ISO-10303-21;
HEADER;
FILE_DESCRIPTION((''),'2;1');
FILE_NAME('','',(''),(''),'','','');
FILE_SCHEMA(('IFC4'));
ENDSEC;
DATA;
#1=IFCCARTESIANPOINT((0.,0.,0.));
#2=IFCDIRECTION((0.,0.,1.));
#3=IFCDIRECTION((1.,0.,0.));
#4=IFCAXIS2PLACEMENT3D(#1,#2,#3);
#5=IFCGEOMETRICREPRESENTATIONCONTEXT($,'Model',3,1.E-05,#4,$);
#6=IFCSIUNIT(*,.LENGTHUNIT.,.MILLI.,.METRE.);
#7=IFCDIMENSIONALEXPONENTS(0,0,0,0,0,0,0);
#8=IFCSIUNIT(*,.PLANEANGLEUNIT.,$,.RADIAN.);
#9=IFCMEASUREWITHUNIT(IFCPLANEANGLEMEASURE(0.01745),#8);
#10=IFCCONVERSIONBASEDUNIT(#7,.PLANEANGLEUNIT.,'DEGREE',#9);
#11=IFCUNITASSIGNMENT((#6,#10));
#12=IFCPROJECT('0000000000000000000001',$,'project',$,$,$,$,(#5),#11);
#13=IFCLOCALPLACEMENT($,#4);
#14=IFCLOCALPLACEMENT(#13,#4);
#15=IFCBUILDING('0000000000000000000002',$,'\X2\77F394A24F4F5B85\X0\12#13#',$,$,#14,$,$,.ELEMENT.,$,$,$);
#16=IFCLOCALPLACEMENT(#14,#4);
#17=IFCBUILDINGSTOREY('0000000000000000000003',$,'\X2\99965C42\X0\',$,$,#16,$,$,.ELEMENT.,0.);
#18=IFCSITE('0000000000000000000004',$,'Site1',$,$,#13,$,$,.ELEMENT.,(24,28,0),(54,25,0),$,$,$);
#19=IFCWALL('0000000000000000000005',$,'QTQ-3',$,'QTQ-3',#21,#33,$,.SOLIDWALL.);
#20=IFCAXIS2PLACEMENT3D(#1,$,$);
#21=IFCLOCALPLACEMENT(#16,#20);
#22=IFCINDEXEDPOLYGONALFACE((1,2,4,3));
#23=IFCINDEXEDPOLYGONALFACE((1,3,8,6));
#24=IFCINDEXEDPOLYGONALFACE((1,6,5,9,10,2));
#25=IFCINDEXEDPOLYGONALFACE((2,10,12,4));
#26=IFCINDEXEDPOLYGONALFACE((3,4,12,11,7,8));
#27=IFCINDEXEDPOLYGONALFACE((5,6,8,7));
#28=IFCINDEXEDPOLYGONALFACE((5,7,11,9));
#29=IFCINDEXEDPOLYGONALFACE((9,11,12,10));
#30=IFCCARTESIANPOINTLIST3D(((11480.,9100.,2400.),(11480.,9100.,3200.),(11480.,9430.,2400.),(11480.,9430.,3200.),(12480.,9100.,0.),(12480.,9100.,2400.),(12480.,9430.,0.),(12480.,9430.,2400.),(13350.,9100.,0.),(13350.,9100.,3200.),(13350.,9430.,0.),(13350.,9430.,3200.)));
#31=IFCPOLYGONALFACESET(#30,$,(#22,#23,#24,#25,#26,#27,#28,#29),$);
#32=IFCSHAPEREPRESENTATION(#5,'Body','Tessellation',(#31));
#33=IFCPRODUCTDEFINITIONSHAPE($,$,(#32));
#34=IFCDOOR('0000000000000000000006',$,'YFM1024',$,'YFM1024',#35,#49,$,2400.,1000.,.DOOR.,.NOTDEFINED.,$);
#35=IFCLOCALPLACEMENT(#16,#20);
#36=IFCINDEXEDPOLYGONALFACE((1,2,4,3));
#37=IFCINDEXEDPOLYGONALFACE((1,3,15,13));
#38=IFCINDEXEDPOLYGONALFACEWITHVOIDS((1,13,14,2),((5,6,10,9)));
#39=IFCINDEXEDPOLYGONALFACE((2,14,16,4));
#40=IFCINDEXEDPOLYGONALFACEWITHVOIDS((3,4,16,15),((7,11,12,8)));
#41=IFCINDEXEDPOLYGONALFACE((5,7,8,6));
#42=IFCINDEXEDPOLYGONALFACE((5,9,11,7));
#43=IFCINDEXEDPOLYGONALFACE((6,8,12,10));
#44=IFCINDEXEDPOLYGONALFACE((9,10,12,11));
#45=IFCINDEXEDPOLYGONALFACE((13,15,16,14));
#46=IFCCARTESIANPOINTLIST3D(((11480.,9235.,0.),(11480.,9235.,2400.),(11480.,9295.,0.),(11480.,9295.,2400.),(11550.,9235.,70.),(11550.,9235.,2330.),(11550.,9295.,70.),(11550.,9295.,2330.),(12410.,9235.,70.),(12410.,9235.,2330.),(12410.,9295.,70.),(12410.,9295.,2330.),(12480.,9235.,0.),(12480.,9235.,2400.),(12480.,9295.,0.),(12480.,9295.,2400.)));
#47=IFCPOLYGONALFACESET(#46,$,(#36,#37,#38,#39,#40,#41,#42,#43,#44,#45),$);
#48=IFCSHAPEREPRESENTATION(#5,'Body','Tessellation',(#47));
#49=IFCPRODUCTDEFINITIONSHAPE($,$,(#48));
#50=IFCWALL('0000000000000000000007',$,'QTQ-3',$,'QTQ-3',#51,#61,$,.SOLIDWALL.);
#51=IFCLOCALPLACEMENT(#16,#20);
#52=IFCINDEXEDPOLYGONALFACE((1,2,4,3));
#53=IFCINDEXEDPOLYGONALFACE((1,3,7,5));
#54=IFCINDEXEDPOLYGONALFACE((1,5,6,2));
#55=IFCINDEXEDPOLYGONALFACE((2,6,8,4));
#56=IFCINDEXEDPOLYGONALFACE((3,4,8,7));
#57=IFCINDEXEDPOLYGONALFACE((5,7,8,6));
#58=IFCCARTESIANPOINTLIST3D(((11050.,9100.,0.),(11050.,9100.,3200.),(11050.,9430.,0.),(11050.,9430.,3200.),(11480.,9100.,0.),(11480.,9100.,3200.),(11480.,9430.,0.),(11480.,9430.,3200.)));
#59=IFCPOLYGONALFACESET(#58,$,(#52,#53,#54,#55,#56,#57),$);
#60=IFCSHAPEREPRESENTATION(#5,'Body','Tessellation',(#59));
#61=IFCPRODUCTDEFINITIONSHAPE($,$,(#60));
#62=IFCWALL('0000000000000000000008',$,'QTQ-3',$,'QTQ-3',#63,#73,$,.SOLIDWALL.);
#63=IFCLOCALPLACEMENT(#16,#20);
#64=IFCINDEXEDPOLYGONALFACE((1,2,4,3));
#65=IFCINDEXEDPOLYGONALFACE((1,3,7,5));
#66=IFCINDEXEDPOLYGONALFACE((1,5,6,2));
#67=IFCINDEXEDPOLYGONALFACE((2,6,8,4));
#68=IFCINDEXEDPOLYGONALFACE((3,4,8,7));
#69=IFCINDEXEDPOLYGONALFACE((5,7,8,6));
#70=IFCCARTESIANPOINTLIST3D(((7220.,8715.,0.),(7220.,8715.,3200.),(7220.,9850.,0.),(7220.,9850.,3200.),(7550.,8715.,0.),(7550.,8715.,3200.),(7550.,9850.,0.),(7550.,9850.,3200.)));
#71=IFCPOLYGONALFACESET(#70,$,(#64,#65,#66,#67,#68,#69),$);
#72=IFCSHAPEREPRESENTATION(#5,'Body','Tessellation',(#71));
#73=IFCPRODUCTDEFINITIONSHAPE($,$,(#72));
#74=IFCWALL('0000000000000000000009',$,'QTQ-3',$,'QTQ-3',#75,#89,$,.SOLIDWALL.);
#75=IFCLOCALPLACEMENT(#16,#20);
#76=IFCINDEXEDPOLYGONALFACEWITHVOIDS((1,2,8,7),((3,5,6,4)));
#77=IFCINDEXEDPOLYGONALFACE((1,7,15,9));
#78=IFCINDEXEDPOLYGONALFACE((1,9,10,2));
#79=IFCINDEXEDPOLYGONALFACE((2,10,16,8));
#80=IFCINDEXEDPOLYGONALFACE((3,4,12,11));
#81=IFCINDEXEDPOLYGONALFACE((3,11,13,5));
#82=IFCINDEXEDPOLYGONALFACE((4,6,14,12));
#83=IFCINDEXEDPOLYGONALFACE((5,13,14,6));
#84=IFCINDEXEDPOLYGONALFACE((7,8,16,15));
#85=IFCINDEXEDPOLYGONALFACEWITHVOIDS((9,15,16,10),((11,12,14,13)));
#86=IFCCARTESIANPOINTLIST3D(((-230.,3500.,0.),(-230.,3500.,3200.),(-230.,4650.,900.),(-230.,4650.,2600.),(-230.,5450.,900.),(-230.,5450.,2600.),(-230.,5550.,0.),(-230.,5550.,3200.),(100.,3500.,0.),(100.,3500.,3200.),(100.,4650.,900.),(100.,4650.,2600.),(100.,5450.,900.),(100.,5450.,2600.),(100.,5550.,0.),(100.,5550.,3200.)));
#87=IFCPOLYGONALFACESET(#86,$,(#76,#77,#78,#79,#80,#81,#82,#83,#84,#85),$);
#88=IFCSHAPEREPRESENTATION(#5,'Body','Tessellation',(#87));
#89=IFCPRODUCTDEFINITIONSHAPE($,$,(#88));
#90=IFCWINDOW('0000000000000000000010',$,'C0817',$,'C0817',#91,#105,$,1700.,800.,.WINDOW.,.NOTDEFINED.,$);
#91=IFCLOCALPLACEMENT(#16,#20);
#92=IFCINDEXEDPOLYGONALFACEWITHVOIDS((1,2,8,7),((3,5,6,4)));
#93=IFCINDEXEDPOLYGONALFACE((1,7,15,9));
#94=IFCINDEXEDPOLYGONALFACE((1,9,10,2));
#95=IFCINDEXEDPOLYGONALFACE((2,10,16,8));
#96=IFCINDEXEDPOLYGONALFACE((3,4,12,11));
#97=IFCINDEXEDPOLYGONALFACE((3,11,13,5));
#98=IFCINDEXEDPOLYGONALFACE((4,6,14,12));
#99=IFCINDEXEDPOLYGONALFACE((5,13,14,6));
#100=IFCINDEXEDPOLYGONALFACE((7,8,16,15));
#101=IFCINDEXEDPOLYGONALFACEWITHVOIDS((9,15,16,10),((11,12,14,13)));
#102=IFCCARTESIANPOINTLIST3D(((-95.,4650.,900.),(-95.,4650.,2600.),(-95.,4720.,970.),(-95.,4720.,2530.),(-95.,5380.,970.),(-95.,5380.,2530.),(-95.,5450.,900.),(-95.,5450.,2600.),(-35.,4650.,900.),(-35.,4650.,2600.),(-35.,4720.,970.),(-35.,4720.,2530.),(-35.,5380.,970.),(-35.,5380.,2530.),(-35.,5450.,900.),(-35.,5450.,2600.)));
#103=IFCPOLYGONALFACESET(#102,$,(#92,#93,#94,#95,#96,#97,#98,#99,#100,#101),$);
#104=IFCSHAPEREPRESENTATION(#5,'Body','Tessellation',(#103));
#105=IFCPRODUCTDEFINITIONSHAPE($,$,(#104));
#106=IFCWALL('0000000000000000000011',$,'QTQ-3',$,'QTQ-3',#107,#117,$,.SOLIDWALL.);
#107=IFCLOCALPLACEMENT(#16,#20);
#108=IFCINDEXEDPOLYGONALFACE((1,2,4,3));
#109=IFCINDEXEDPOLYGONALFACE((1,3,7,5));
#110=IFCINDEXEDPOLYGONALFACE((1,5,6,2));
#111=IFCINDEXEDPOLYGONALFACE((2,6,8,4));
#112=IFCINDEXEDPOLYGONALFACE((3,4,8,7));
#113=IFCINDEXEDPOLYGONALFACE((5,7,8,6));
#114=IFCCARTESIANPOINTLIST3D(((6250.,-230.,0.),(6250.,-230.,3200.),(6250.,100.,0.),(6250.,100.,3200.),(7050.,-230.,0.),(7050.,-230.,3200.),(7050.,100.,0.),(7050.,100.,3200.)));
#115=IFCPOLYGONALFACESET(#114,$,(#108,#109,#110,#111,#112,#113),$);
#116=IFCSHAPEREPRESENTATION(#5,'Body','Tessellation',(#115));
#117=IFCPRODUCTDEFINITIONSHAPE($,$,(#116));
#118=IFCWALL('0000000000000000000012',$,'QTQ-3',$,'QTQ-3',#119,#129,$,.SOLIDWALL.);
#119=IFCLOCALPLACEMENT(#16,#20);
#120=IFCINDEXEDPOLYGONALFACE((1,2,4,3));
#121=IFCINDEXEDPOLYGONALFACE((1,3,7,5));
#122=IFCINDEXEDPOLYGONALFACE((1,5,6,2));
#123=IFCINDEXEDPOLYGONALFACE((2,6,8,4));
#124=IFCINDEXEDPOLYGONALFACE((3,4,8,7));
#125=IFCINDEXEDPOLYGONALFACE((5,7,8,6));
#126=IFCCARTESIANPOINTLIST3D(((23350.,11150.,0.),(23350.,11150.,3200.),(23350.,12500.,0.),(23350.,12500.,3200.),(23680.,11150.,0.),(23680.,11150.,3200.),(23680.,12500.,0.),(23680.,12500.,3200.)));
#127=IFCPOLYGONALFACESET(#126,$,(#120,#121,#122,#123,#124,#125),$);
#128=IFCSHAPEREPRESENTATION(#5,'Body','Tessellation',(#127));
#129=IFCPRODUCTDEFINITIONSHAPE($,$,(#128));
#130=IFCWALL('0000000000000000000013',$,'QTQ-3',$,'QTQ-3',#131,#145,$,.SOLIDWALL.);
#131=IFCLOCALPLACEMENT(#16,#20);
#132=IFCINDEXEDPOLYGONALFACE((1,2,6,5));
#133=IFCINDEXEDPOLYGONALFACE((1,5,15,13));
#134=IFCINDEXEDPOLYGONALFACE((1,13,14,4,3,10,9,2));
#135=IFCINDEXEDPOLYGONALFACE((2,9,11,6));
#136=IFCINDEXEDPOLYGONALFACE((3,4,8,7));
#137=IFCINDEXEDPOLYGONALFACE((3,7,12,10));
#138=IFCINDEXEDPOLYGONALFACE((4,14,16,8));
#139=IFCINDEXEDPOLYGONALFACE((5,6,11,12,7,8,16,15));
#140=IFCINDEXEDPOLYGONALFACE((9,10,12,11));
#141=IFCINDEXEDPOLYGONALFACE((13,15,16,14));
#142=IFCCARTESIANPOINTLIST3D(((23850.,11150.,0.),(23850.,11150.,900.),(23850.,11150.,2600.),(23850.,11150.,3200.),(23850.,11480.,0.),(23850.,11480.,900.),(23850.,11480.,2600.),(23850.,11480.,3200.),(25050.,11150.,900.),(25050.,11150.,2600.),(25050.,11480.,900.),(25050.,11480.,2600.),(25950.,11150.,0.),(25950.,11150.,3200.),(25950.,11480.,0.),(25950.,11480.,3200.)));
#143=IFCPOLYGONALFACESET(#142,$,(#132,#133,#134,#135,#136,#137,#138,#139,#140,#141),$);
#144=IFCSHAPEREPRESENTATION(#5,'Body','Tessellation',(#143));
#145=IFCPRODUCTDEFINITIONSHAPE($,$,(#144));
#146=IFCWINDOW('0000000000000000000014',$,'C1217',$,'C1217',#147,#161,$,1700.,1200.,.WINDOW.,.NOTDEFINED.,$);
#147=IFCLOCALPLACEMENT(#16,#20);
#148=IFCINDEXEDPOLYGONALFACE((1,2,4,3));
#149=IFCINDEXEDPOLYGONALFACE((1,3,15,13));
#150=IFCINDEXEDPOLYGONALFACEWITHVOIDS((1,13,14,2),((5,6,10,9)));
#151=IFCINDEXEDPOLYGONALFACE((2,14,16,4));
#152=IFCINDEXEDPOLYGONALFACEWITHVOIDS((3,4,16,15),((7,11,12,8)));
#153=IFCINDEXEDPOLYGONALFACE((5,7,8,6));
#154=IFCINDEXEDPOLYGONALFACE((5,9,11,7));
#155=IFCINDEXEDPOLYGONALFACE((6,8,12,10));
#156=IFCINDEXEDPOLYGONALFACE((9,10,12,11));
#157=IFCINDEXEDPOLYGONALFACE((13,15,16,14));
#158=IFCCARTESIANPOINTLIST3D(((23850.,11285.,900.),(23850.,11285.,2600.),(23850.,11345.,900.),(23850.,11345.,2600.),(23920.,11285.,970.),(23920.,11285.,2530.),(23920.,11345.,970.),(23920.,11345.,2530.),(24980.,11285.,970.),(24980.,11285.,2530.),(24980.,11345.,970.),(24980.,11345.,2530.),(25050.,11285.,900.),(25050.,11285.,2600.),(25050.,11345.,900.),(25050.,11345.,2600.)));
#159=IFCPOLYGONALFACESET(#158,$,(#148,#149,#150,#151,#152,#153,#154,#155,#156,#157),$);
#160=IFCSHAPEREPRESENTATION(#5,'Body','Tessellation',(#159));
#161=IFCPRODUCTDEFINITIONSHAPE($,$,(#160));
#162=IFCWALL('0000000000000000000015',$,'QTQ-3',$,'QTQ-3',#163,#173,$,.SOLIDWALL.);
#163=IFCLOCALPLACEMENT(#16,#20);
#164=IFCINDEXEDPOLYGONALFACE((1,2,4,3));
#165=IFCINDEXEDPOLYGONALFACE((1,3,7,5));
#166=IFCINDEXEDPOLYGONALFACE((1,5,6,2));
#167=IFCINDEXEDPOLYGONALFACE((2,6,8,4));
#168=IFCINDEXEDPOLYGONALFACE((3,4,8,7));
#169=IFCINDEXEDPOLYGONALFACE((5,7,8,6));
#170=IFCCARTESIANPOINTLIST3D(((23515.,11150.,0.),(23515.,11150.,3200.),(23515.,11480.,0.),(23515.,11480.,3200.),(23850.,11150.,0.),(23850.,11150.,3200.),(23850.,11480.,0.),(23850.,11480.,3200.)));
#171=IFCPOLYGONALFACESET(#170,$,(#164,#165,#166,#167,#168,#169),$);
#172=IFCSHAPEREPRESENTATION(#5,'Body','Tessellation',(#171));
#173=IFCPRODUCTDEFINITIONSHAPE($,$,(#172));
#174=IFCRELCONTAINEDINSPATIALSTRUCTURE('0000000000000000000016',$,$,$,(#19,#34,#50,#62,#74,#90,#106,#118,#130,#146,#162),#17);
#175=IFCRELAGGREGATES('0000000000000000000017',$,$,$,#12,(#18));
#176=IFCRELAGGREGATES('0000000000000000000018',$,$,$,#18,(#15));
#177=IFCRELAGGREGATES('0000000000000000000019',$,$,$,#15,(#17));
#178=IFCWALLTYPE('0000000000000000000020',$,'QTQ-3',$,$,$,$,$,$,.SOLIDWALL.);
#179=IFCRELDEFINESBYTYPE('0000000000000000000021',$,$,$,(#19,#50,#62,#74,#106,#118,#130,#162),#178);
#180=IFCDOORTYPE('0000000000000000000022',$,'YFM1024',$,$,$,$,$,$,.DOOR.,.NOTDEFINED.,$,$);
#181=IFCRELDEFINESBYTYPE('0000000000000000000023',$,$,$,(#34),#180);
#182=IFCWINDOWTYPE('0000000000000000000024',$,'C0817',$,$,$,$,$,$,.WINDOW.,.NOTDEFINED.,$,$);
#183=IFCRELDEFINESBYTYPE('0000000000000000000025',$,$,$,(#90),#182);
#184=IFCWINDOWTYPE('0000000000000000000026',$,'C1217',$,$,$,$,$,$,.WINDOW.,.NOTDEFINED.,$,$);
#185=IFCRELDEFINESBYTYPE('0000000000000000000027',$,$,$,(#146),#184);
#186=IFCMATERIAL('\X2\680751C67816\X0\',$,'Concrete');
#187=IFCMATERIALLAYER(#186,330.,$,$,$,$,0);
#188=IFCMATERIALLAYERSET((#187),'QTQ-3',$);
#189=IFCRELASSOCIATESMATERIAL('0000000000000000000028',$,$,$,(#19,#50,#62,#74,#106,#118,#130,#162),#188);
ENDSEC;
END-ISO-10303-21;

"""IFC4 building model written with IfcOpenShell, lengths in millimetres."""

from ifc_helpers import new_model, entity, si_unit, converted_unit, frame, origin_with_axes, place, context, project, spatial, polyline, outline, extrude, material, layer, layer_set, type_object, element, fill, save


model = new_model("IFC4")

# Units and contexts
model_context = context("Model", 3, precision=1e-05, world=origin_with_axes())
ifc_project = project(units=[si_unit("LENGTHUNIT", "METRE", prefix="MILLI"), converted_unit("PLANEANGLEUNIT", "DEGREE", entity("IfcPlaneAngleMeasure", 0.01745), si_unit("PLANEANGLEUNIT", "RADIAN"), dimensions=[0, 0, 0, 0, 0, 0, 0])], contexts=[model_context])

# Site, building, storey
site_placement = place(None, origin_with_axes())
site = spatial("IfcSite", under=ifc_project, at=site_placement, Name="Site1", CompositionType="ELEMENT", RefLatitude=(24, 28, 0), RefLongitude=(54, 25, 0))
building_placement = place(site_placement, origin_with_axes())
building = spatial("IfcBuilding", under=site, at=building_placement, Name="石钢住宅12#13#", CompositionType="ELEMENT")
storey_placement = place(building_placement, origin_with_axes())
storey = spatial("IfcBuildingStorey", under=building, at=storey_placement, Name="首层", CompositionType="ELEMENT", Elevation=0.0)

# Shared definitions
ifc_material = material(Name="标准砖", Category="Concrete")
ifc_layer = layer(ifc_material, 330.0, Priority=0)
ifc_layer_set = layer_set([ifc_layer], Name="QTQ-3")
wall_type = type_object("IfcWallType", Name="QTQ-3", PredefinedType="SOLIDWALL")

# Shared definitions
window_type_1 = type_object("IfcWindowType", Name="C0817", PartitioningType="NOTDEFINED", PredefinedType="WINDOW")

# Wall, opening, door
wall_1_placement = place(storey_placement, origin_with_axes())
wall_1 = element("IfcWall", 1, at=wall_1_placement, inside=storey, type_object=wall_type, material=ifc_layer_set, Name="QTQ-3", ObjectType="QTQ-3", PredefinedType="SOLIDWALL", context=model_context, shape_type="SweptSolid", body=[
    extrude(outline(polyline([(0.0, 0.0), (3200.0, 0.0), (3200.0, 1870.0), (0.0, 1870.0), (0.0, 0.0)])), frame((11480.0, 9430.0, 3200.0), z_axis=(0.0, -1.0, 0.0), x_axis=(0.0, 0.0, -1.0)), (0.0, 0.0, 1.0), 330.0),
])
opening_1_placement = place(storey_placement, origin_with_axes())
opening_1 = element("IfcOpeningElement", 2, at=opening_1_placement, cuts=wall_1, PredefinedType="OPENING", context=model_context, shape_type="SweptSolid", body=[
    extrude(outline(polyline([(0.0, 0.0), (1000.0, 0.0), (1000.0, 2400.0), (0.0, 2400.0), (0.0, 0.0)])), frame((11480.0, 10430.0, 0.0), z_axis=(0.0, -1.0, 0.0), x_axis=(1.0, 0.0, 0.0)), (0.0, 0.0, 1.0), 2330.0),
])
door_type_1 = type_object("IfcDoorType", Name="YFM1024", OperationType="NOTDEFINED", PredefinedType="DOOR")
door_1_placement = place(storey_placement, origin_with_axes())
door_1 = element("IfcDoor", 3, at=door_1_placement, inside=storey, type_object=door_type_1, Name="YFM1024", ObjectType="YFM1024", OperationType="NOTDEFINED", OverallHeight=2400.0, OverallWidth=1000.0, PredefinedType="DOOR", context=model_context, shape_type="SweptSolid", body=[
    extrude(outline(polyline([(-500.0, -1200.0), (500.0, -1200.0), (500.0, 1200.0), (-500.0, 1200.0), (-500.0, -1200.0)]), holes=[polyline([(-430.0, -1130.0), (-430.0, 1130.0), (430.0, 1130.0), (430.0, -1130.0), (-430.0, -1130.0)])]), frame((11980.0, 9295.0, 1200.0), z_axis=(0.0, -1.0, 0.0), x_axis=(1.0, 0.0, 0.0)), (0.0, 0.0, 1.0), 60.0),
])
fill(opening_1, door_1)

# Walls
wall_2_placement = place(storey_placement, origin_with_axes())
element("IfcWall", 4, at=wall_2_placement, inside=storey, type_object=wall_type, material=ifc_layer_set, Name="QTQ-3", ObjectType="QTQ-3", PredefinedType="SOLIDWALL", context=model_context, shape_type="SweptSolid", body=[
    extrude(outline(polyline([(0.0, 0.0), (3200.0, 0.0), (3200.0, 430.0), (0.0, 430.0), (0.0, 0.0)])), frame((11050.0, 9430.0, 3200.0), z_axis=(0.0, -1.0, 0.0), x_axis=(0.0, 0.0, -1.0)), (0.0, 0.0, 1.0), 330.0),
])
wall_3_placement = place(storey_placement, origin_with_axes())
element("IfcWall", 5, at=wall_3_placement, inside=storey, type_object=wall_type, material=ifc_layer_set, Name="QTQ-3", ObjectType="QTQ-3", PredefinedType="SOLIDWALL", context=model_context, shape_type="SweptSolid", body=[
    extrude(outline(polyline([(0.0, 0.0), (3200.0, 0.0), (3200.0, 1135.0), (0.0, 1135.0), (0.0, 0.0)])), frame((7220.0, 8715.0, 3200.0), z_axis=(1.0, 0.0, 0.0), x_axis=(0.0, 0.0, -1.0)), (0.0, 0.0, 1.0), 330.0),
])

# Wall, opening, window
wall_4_placement = place(storey_placement, origin_with_axes())
wall_4 = element("IfcWall", 6, at=wall_4_placement, inside=storey, type_object=wall_type, material=ifc_layer_set, Name="QTQ-3", ObjectType="QTQ-3", PredefinedType="SOLIDWALL", context=model_context, shape_type="SweptSolid", body=[
    extrude(outline(polyline([(0.0, 0.0), (3200.0, 0.0), (3200.0, 2050.0), (0.0, 2050.0), (0.0, 0.0)])), frame((100.0, 5550.0, 3200.0), z_axis=(-1.0, 0.0, 0.0), x_axis=(0.0, 0.0, -1.0)), (0.0, 0.0, 1.0), 330.0),
])
opening_2_placement = place(storey_placement, origin_with_axes())
opening_2 = element("IfcOpeningElement", 7, at=opening_2_placement, cuts=wall_4, PredefinedType="OPENING", context=model_context, shape_type="SweptSolid", body=[
    extrude(outline(polyline([(0.0, 0.0), (800.0, 0.0), (800.0, 1700.0), (0.0, 1700.0), (0.0, 0.0)])), frame((1100.0, 5450.0, 900.0), z_axis=(-1.0, 0.0, 0.0), x_axis=(0.0, -1.0, 0.0)), (0.0, 0.0, 1.0), 2330.0),
])
window_1_placement = place(storey_placement, origin_with_axes())
window_1 = element("IfcWindow", 8, at=window_1_placement, inside=storey, type_object=window_type_1, Name="C0817", ObjectType="C0817", OverallHeight=1700.0, OverallWidth=800.0, PartitioningType="NOTDEFINED", PredefinedType="WINDOW", context=model_context, shape_type="SweptSolid", body=[
    extrude(outline(polyline([(-400.0, -850.0), (400.0, -850.0), (400.0, 850.0), (-400.0, 850.0), (-400.0, -850.0)]), holes=[polyline([(-330.0, -780.0), (-330.0, 780.0), (330.0, 780.0), (330.0, -780.0), (-330.0, -780.0)])]), frame((-35.0, 5050.0, 1750.0), z_axis=(-1.0, 0.0, 0.0), x_axis=(0.0, -1.0, 0.0)), (0.0, 0.0, 1.0), 60.0),
])
fill(opening_2, window_1)

# Walls
wall_5_placement = place(storey_placement, origin_with_axes())
element("IfcWall", 9, at=wall_5_placement, inside=storey, type_object=wall_type, material=ifc_layer_set, Name="QTQ-3", ObjectType="QTQ-3", PredefinedType="SOLIDWALL", context=model_context, shape_type="SweptSolid", body=[
    extrude(outline(polyline([(0.0, 0.0), (3200.0, 0.0), (3200.0, 800.0), (0.0, 800.0), (0.0, 0.0)])), frame((6250.0, 100.0, 3200.0), z_axis=(0.0, -1.0, 0.0), x_axis=(0.0, 0.0, -1.0)), (0.0, 0.0, 1.0), 330.0),
])
wall_6_placement = place(storey_placement, origin_with_axes())
element("IfcWall", 10, at=wall_6_placement, inside=storey, type_object=wall_type, material=ifc_layer_set, Name="QTQ-3", ObjectType="QTQ-3", PredefinedType="SOLIDWALL", context=model_context, shape_type="SweptSolid", body=[
    extrude(outline(polyline([(0.0, 0.0), (3200.0, 0.0), (3200.0, 1350.0), (0.0, 1350.0), (0.0, 0.0)])), frame((23680.0, 12500.0, 3200.0), z_axis=(-1.0, 0.0, 0.0), x_axis=(0.0, 0.0, -1.0)), (0.0, 0.0, 1.0), 330.0),
])

# Wall, opening, window
wall_7_placement = place(storey_placement, origin_with_axes())
wall_7 = element("IfcWall", 11, at=wall_7_placement, inside=storey, type_object=wall_type, material=ifc_layer_set, Name="QTQ-3", ObjectType="QTQ-3", PredefinedType="SOLIDWALL", context=model_context, shape_type="SweptSolid", body=[
    extrude(outline(polyline([(0.0, 0.0), (3200.0, 0.0), (3200.0, 2100.0), (0.0, 2100.0), (0.0, 0.0)])), frame((23850.0, 11480.0, 3200.0), z_axis=(0.0, -1.0, 0.0), x_axis=(0.0, 0.0, -1.0)), (0.0, 0.0, 1.0), 330.0),
])
opening_3_placement = place(storey_placement, origin_with_axes())
opening_3 = element("IfcOpeningElement", 12, at=opening_3_placement, cuts=wall_7, PredefinedType="OPENING", context=model_context, shape_type="SweptSolid", body=[
    extrude(outline(polyline([(0.0, 0.0), (1200.0, 0.0), (1200.0, 1700.0), (0.0, 1700.0), (0.0, 0.0)])), frame((23850.0, 12480.0, 900.0), z_axis=(0.0, -1.0, 0.0), x_axis=(1.0, 0.0, 0.0)), (0.0, 0.0, 1.0), 2330.0),
])
window_type_2 = type_object("IfcWindowType", Name="C1217", PartitioningType="NOTDEFINED", PredefinedType="WINDOW")
window_2_placement = place(storey_placement, origin_with_axes())
window_2 = element("IfcWindow", 13, at=window_2_placement, inside=storey, type_object=window_type_2, Name="C1217", ObjectType="C1217", OverallHeight=1700.0, OverallWidth=1200.0, PartitioningType="NOTDEFINED", PredefinedType="WINDOW", context=model_context, shape_type="SweptSolid", body=[
    extrude(outline(polyline([(-600.0, -850.0), (600.0, -850.0), (600.0, 850.0), (-600.0, 850.0), (-600.0, -850.0)]), holes=[polyline([(-530.0, -780.0), (-530.0, 780.0), (530.0, 780.0), (530.0, -780.0), (-530.0, -780.0)])]), frame((24450.0, 11345.0, 1750.0), z_axis=(0.0, -1.0, 0.0), x_axis=(1.0, 0.0, 0.0)), (0.0, 0.0, 1.0), 60.0),
])
fill(opening_3, window_2)

# Wall
wall_8_placement = place(storey_placement, origin_with_axes())
element("IfcWall", 14, at=wall_8_placement, inside=storey, type_object=wall_type, material=ifc_layer_set, Name="QTQ-3", ObjectType="QTQ-3", PredefinedType="SOLIDWALL", context=model_context, shape_type="SweptSolid", body=[
    extrude(outline(polyline([(0.0, 0.0), (3200.0, 0.0), (3200.0, 335.0), (0.0, 335.0), (0.0, 0.0)])), frame((23515.0, 11480.0, 3200.0), z_axis=(0.0, -1.0, 0.0), x_axis=(0.0, 0.0, -1.0)), (0.0, 0.0, 1.0), 330.0),
])

save(model, "model.ifc")
